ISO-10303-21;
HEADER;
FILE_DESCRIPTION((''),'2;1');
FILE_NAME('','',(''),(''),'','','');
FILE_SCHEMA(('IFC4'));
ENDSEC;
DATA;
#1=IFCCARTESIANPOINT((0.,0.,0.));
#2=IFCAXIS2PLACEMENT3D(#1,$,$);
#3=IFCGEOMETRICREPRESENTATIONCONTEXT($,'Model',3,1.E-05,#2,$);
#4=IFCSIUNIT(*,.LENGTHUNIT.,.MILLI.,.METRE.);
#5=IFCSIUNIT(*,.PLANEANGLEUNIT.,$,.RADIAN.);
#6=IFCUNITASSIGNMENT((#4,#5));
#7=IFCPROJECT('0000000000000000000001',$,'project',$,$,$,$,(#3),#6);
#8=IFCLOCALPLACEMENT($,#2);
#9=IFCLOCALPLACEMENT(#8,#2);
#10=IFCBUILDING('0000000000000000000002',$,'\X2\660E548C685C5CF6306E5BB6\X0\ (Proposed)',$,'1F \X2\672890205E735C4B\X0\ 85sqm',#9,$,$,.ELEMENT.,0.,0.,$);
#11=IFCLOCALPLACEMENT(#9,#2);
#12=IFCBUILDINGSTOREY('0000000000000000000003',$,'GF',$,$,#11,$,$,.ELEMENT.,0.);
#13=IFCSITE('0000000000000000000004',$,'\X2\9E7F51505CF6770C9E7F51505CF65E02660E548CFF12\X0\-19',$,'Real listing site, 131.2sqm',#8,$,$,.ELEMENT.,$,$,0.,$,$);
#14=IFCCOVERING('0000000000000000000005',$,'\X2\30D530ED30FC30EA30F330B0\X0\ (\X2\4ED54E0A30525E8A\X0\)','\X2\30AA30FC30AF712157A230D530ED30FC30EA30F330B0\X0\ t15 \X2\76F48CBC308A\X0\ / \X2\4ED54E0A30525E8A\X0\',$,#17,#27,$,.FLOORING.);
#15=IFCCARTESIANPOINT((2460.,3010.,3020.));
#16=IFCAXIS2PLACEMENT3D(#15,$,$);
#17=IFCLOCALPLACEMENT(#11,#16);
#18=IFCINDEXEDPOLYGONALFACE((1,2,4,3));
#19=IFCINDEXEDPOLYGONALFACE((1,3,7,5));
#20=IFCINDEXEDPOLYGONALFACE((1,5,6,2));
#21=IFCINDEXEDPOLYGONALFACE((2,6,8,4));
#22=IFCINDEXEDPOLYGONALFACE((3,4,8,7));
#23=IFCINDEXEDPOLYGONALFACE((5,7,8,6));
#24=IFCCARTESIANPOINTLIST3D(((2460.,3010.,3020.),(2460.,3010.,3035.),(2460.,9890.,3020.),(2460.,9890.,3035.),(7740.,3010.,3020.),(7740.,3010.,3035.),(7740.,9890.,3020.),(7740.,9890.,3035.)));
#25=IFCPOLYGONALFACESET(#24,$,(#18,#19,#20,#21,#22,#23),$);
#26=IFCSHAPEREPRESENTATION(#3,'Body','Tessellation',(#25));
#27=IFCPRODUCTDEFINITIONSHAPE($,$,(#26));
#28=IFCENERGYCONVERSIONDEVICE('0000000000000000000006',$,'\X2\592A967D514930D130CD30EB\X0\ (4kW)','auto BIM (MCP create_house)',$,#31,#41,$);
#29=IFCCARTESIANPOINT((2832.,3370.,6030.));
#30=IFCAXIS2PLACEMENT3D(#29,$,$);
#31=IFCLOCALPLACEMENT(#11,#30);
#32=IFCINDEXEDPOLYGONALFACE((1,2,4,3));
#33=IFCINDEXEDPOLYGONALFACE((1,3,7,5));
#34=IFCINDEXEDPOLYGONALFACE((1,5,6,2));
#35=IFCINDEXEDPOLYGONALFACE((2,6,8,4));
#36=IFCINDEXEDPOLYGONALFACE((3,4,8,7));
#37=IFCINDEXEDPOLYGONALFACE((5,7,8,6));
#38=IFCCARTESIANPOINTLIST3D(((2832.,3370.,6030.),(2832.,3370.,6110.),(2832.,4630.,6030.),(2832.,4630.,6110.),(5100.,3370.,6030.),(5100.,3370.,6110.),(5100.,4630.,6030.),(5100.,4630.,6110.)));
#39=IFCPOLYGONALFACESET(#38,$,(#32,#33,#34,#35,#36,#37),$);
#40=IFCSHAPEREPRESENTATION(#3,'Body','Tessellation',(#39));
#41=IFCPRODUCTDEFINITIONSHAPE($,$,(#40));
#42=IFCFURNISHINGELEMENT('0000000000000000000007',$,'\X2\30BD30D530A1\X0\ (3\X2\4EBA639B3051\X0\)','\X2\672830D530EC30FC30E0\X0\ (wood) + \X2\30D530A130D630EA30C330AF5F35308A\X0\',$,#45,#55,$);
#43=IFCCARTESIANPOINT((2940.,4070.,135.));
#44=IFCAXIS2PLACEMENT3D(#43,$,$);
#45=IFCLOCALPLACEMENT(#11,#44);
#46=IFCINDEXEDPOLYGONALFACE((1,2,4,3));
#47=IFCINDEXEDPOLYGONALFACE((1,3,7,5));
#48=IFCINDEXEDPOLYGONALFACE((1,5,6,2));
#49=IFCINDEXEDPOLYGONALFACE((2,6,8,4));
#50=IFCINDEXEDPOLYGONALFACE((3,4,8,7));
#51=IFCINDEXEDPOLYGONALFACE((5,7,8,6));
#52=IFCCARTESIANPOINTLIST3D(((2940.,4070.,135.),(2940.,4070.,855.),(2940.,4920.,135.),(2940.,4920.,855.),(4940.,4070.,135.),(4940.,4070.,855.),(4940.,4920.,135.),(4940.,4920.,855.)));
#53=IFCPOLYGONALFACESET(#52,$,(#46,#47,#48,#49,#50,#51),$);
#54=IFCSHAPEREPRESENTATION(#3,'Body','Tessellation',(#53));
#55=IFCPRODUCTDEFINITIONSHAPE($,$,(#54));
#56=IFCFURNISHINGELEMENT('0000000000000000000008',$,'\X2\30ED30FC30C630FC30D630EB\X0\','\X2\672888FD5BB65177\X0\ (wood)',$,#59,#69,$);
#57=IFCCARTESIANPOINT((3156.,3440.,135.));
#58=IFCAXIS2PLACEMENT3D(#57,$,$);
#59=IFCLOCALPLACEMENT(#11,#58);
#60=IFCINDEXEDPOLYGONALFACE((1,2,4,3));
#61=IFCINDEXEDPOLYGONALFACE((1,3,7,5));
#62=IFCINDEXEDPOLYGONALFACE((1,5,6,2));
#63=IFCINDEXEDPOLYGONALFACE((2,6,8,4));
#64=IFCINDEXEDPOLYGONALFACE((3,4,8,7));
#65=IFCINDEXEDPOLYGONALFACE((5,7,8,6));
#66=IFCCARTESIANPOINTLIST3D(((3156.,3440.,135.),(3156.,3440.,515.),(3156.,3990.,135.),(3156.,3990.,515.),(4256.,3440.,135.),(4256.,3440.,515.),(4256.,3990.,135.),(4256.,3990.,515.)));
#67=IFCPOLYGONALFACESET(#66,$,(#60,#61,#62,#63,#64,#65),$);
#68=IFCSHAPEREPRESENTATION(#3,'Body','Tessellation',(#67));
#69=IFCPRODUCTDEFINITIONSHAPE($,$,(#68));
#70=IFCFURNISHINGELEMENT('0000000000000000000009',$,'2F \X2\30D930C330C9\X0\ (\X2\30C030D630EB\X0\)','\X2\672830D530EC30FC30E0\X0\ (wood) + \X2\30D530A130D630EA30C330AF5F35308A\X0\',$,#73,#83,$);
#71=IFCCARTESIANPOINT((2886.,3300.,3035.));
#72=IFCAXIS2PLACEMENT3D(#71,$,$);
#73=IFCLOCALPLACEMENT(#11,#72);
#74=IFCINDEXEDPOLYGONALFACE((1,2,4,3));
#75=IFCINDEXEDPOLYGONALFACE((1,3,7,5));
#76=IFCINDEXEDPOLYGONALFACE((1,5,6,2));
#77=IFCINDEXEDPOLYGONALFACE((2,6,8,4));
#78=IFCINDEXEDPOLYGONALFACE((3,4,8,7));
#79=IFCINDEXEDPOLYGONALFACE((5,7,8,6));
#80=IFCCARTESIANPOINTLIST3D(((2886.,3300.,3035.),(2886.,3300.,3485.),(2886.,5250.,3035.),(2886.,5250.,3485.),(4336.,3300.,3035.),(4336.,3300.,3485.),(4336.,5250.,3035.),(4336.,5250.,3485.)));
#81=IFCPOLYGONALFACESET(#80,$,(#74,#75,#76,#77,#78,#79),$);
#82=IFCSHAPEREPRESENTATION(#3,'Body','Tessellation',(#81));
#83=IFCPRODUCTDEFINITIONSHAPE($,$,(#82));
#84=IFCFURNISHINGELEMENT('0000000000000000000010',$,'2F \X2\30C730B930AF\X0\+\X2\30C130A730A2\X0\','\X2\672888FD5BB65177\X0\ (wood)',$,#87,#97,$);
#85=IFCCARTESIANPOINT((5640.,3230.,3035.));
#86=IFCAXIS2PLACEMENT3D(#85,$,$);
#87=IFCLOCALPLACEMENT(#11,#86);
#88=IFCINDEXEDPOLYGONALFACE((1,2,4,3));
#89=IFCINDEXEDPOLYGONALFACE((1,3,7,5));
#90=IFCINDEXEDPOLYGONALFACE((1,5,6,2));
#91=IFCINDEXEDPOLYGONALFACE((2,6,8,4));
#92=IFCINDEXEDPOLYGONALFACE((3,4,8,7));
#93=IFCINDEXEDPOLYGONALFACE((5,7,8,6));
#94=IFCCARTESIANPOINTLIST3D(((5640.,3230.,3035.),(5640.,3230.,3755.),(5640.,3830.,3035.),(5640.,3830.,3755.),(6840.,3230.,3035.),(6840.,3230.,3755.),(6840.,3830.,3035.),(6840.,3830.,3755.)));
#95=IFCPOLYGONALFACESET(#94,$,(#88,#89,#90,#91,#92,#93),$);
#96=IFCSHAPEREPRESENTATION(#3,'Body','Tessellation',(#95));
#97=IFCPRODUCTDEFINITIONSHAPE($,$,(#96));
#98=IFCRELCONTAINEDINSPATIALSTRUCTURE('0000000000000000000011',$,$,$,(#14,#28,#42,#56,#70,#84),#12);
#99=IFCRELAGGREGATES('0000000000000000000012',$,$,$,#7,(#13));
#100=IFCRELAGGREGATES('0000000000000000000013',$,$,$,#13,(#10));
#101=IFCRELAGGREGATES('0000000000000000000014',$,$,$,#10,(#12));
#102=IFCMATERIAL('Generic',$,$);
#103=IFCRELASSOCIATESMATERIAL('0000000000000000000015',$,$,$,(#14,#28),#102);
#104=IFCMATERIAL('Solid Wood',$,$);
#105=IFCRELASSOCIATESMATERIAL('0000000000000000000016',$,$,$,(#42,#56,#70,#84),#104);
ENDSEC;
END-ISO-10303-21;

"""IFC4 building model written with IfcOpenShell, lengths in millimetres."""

from ifc_helpers import new_model, si_unit, frame, frame_2d, origin, place, context, project, spatial, rectangle, extrude, material, element, save


model = new_model("IFC4")

# Units and contexts
model_context = context("Model", 3, precision=1e-05, world=origin())
ifc_project = project(units=[si_unit("LENGTHUNIT", "METRE", prefix="MILLI"), si_unit("PLANEANGLEUNIT", "RADIAN")], contexts=[model_context])

# Site, building, storey
site_placement = place(None, origin())
site = spatial("IfcSite", under=ifc_project, at=site_placement, Name="鹿児島県鹿児島市明和２-19", ObjectType="Real listing site, 131.2sqm", CompositionType="ELEMENT", RefElevation=0.0)
building_placement = place(site_placement, origin())
building = spatial("IfcBuilding", under=site, at=building_placement, Name="明和桜島の家 (Proposed)", ObjectType="1F 木造平屋 85sqm", CompositionType="ELEMENT", ElevationOfRefHeight=0.0, ElevationOfTerrain=0.0)
storey_placement = place(building_placement, origin())
storey = spatial("IfcBuildingStorey", under=building, at=storey_placement, Name="GF", CompositionType="ELEMENT", Elevation=0.0)

# Shared definitions
ifc_material_1 = material(Name="Solid Wood")

# Shared definitions
ifc_material_2 = material(Name="Generic")

# Covering
covering_placement = place(storey_placement, frame((2460.0, 3010.0, 3020.0)))
element("IfcCovering", 1, at=covering_placement, inside=storey, material=ifc_material_2, Name="フローリング (仕上げ床)", Description="オーク無垢フローリング t15 直貼り / 仕上げ床", PredefinedType="FLOORING", context=model_context, shape_type="SweptSolid", body=[
    extrude(rectangle(XDim=5280.0, YDim=6880.0, at=frame_2d((2640.0, 3440.0))), frame((2460.0, 3010.0, 3020.0)), (0.0, 0.0, 1.0), 15.0),
])

# Energy conversion device
energy_conversion_device_placement = place(storey_placement, frame((2832.0, 3370.0, 6030.0)))
element("IfcEnergyConversionDevice", 2, at=energy_conversion_device_placement, inside=storey, material=ifc_material_2, Name="太陽光パネル (4kW)", Description="auto BIM (MCP create_house)", context=model_context, shape_type="SweptSolid", body=[
    extrude(rectangle(XDim=2268.0, YDim=1260.0, at=frame_2d((1134.0, 630.0))), frame((2832.0, 3370.0, 6030.0)), (0.0, 0.0, 1.0), 80.0),
])

# Furnishing elements
furnishing_1_placement = place(storey_placement, frame((2940.0, 4070.0, 135.0)))
element("IfcFurnishingElement", 3, at=furnishing_1_placement, inside=storey, material=ifc_material_1, Name="ソファ (3人掛け)", Description="木フレーム (wood) + ファブリック張り", context=model_context, shape_type="SweptSolid", body=[
    extrude(rectangle(XDim=2000.0, YDim=850.0, at=frame_2d((1000.0, 425.0))), frame((2940.0, 4070.0, 135.0)), (0.0, 0.0, 1.0), 720.0),
])
furnishing_2_placement = place(storey_placement, frame((3156.0, 3440.0, 135.0)))
element("IfcFurnishingElement", 4, at=furnishing_2_placement, inside=storey, material=ifc_material_1, Name="ローテーブル", Description="木製家具 (wood)", context=model_context, shape_type="SweptSolid", body=[
    extrude(rectangle(XDim=1100.0, YDim=550.0, at=frame_2d((550.0, 275.0))), frame((3156.0, 3440.0, 135.0)), (0.0, 0.0, 1.0), 380.0),
])
furnishing_3_placement = place(storey_placement, frame((2886.0, 3300.0, 3035.0)))
element("IfcFurnishingElement", 5, at=furnishing_3_placement, inside=storey, material=ifc_material_1, Name="2F ベッド (ダブル)", Description="木フレーム (wood) + ファブリック張り", context=model_context, shape_type="SweptSolid", body=[
    extrude(rectangle(XDim=1450.0, YDim=1950.0, at=frame_2d((725.0, 975.0))), frame((2886.0, 3300.0, 3035.0)), (0.0, 0.0, 1.0), 450.0),
])
furnishing_4_placement = place(storey_placement, frame((5640.0, 3230.0, 3035.0)))
element("IfcFurnishingElement", 6, at=furnishing_4_placement, inside=storey, material=ifc_material_1, Name="2F デスク+チェア", Description="木製家具 (wood)", context=model_context, shape_type="SweptSolid", body=[
    extrude(rectangle(XDim=1200.0, YDim=600.0, at=frame_2d((600.0, 300.0))), frame((5640.0, 3230.0, 3035.0)), (0.0, 0.0, 1.0), 720.0),
])

save(model, "model.ifc")
